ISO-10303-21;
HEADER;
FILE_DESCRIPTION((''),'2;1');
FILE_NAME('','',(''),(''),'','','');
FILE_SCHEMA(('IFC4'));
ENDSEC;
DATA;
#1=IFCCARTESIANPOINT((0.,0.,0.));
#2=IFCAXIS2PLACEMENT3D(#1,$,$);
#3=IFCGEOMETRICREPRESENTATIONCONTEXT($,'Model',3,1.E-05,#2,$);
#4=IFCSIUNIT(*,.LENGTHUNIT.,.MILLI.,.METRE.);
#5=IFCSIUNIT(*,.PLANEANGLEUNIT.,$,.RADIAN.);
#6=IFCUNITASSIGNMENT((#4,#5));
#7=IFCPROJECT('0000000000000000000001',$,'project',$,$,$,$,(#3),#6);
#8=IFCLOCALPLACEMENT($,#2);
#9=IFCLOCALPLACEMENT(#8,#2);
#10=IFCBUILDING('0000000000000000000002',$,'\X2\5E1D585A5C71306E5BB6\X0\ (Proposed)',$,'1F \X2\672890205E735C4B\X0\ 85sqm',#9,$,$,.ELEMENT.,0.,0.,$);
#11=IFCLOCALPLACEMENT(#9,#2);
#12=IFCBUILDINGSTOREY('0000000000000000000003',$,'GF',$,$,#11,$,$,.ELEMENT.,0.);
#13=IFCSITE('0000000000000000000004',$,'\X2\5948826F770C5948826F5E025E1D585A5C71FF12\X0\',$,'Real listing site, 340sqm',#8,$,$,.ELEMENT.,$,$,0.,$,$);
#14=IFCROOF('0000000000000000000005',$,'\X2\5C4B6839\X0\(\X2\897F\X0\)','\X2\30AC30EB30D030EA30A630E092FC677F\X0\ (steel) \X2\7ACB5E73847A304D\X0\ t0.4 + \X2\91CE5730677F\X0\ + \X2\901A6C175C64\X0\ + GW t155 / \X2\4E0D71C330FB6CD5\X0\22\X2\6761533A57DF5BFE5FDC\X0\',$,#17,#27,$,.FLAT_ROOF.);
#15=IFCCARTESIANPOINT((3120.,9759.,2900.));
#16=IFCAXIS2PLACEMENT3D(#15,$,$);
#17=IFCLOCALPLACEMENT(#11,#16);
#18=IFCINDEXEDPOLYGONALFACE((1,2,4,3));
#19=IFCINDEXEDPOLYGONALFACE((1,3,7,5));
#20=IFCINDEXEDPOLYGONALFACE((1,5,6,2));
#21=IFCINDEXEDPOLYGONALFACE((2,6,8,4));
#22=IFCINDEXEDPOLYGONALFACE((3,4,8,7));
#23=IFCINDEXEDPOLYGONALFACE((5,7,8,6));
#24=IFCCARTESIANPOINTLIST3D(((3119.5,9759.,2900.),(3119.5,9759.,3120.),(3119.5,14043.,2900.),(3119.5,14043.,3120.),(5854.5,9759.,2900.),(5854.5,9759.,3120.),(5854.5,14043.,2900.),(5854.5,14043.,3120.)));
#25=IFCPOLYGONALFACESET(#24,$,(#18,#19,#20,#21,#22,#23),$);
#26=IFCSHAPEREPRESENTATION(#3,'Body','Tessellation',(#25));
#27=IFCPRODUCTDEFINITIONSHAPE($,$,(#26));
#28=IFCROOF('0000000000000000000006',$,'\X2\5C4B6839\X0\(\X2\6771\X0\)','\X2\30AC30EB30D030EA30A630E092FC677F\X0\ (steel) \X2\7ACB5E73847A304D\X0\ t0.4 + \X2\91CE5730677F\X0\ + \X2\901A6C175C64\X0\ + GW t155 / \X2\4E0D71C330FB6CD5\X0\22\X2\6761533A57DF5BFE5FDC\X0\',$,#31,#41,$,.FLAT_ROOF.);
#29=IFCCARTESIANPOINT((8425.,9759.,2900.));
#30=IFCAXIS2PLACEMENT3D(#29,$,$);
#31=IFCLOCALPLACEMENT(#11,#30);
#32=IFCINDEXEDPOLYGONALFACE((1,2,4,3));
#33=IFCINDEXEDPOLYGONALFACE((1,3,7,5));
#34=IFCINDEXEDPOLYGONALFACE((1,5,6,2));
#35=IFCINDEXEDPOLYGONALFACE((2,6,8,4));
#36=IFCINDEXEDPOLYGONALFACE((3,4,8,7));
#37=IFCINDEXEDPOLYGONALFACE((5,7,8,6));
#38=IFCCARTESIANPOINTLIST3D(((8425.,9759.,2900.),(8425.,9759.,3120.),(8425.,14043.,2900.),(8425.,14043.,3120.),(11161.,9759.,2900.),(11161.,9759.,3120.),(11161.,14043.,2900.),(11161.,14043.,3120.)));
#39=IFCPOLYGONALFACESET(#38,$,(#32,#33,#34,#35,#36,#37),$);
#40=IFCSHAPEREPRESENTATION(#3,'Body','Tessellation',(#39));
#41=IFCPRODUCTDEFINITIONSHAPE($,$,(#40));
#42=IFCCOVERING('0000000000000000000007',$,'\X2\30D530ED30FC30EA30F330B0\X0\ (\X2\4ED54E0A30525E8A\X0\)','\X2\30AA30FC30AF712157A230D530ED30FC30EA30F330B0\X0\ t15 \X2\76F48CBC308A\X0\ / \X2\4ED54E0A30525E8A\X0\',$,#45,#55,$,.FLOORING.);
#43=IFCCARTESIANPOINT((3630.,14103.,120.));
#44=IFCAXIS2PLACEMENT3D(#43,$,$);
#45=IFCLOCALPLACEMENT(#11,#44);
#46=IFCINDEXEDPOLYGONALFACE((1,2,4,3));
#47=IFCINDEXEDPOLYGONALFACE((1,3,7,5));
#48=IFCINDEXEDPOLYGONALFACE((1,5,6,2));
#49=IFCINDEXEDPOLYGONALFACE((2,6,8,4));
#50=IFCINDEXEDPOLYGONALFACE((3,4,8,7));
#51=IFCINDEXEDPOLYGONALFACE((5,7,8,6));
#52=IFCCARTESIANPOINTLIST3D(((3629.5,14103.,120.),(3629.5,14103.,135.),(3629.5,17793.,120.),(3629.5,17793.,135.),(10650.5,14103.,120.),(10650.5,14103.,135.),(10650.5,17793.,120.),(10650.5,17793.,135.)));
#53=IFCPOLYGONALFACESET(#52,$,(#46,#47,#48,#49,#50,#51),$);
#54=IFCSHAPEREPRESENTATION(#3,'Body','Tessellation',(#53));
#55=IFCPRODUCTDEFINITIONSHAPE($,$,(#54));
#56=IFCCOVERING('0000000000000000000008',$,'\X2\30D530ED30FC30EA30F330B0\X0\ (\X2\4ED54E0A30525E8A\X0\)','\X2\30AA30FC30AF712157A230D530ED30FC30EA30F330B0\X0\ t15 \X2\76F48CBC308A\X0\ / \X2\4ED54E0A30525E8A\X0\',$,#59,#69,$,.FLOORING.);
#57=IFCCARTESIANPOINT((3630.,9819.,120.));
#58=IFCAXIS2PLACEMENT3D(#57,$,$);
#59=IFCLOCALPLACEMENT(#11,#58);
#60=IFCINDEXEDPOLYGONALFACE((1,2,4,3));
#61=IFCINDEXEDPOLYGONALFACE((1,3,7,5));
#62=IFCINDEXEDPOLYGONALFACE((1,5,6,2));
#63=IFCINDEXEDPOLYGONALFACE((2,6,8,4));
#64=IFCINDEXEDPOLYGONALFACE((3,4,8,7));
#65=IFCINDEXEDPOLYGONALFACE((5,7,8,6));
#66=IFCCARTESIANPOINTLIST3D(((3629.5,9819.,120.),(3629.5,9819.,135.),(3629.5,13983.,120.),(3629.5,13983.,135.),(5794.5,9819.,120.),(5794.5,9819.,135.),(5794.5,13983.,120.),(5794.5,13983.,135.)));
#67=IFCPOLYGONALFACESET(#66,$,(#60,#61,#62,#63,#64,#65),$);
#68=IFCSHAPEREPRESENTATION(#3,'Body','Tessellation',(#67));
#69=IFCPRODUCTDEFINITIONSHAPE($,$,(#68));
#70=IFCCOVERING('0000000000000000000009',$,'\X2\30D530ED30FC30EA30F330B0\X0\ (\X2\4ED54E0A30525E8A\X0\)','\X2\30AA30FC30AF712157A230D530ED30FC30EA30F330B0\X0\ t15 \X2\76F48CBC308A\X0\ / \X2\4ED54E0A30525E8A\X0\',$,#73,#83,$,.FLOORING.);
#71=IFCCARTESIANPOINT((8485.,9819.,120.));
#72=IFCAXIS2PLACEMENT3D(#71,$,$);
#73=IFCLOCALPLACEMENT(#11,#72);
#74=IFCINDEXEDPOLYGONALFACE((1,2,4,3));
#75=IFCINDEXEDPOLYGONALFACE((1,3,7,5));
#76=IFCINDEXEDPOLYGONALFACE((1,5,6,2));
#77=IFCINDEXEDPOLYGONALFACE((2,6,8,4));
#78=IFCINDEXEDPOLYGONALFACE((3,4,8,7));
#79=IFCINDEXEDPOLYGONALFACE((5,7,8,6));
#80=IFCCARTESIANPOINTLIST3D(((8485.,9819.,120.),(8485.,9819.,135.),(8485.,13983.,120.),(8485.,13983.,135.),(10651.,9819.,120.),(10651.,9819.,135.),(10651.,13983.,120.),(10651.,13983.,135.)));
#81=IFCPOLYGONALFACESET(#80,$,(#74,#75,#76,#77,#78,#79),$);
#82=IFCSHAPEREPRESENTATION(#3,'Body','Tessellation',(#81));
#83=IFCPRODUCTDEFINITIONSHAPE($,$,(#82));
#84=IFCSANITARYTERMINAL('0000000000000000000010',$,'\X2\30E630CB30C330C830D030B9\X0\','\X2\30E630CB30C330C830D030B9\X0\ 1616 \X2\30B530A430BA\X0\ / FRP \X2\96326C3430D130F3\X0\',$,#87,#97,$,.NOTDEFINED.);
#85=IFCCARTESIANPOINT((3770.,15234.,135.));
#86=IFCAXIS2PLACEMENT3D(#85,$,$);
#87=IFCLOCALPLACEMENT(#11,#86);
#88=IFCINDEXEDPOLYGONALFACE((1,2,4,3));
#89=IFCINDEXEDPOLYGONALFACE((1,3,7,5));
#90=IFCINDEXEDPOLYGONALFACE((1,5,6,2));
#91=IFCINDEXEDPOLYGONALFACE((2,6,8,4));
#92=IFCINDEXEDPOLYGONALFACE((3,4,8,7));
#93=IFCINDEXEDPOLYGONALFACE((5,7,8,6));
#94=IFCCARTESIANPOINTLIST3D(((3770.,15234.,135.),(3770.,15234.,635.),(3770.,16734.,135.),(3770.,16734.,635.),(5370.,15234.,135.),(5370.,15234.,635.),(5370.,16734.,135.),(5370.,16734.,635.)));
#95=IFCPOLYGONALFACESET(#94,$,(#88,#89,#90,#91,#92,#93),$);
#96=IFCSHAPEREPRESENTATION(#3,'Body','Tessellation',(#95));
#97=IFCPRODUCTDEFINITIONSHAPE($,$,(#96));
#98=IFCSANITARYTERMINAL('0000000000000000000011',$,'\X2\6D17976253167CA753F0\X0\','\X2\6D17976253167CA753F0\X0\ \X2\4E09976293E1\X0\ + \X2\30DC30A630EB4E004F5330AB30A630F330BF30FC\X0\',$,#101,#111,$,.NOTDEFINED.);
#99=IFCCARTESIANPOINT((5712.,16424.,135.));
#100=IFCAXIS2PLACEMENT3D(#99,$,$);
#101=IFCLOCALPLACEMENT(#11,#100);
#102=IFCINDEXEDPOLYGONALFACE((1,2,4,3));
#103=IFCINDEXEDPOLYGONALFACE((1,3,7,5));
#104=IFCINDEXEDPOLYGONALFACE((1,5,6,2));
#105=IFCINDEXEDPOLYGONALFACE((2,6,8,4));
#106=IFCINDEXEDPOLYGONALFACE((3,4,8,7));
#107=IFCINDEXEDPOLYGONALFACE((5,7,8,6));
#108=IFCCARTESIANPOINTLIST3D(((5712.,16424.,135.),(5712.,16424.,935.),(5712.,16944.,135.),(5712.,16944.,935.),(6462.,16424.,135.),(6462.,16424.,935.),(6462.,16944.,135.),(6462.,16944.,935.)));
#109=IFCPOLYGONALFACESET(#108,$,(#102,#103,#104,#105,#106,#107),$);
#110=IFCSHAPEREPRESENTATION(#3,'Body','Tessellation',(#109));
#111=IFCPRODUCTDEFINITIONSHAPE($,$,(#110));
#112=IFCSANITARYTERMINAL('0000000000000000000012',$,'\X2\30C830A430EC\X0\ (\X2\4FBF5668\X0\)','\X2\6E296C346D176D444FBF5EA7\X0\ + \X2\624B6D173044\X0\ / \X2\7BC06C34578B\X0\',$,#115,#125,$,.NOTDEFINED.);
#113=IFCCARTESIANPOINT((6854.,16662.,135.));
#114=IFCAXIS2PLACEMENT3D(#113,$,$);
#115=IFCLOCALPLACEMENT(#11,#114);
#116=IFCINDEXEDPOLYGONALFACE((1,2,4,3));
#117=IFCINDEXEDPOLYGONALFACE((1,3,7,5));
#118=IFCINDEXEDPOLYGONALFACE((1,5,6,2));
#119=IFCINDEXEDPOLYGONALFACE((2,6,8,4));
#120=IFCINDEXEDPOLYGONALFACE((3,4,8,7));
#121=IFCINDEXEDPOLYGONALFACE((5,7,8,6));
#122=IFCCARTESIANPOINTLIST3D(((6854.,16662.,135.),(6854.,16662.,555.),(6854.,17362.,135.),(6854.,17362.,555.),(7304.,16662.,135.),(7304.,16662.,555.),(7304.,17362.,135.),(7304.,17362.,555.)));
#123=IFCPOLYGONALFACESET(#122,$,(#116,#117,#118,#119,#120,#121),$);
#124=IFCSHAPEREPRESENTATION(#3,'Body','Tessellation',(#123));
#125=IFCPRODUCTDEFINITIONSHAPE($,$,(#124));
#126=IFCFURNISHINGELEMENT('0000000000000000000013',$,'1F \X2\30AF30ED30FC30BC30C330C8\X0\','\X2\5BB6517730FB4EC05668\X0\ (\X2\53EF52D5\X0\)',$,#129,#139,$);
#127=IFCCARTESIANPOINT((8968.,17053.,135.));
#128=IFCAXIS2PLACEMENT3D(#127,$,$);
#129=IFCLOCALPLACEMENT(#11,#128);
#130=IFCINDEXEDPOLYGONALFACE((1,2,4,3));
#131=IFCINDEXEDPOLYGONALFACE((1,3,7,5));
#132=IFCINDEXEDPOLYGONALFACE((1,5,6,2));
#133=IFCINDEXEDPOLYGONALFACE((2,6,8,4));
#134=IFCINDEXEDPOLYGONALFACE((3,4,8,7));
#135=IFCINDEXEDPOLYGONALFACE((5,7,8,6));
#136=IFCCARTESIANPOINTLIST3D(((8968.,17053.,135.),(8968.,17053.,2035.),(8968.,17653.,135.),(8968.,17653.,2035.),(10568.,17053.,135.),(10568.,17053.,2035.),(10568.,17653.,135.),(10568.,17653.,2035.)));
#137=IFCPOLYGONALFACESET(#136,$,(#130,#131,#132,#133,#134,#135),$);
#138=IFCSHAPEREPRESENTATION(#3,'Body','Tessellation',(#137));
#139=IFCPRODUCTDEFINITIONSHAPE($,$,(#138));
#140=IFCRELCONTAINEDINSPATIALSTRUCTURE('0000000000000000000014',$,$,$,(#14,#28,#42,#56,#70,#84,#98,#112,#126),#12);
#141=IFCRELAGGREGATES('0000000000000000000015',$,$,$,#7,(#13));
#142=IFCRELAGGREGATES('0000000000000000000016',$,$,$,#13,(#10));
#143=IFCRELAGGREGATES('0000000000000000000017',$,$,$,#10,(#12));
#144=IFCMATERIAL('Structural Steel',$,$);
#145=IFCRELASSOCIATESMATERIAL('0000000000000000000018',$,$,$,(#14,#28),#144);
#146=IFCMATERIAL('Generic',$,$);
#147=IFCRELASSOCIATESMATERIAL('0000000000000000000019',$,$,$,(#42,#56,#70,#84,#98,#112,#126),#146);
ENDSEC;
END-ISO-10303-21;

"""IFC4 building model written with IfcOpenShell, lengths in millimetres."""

from ifc_helpers import new_model, si_unit, frame, frame_2d, origin, place, context, project, spatial, rectangle, extrude, material, element, save


model = new_model("IFC4")

# Units and contexts
model_context = context("Model", 3, precision=1e-05, world=origin())
ifc_project = project(units=[si_unit("LENGTHUNIT", "METRE", prefix="MILLI"), si_unit("PLANEANGLEUNIT", "RADIAN")], contexts=[model_context])

# Site, building, storey
site_placement = place(None, origin())
site = spatial("IfcSite", under=ifc_project, at=site_placement, Name="奈良県奈良市帝塚山２", ObjectType="Real listing site, 340sqm", CompositionType="ELEMENT", RefElevation=0.0)
building_placement = place(site_placement, origin())
building = spatial("IfcBuilding", under=site, at=building_placement, Name="帝塚山の家 (Proposed)", ObjectType="1F 木造平屋 85sqm", CompositionType="ELEMENT", ElevationOfRefHeight=0.0, ElevationOfTerrain=0.0)
storey_placement = place(building_placement, origin())
storey = spatial("IfcBuildingStorey", under=building, at=storey_placement, Name="GF", CompositionType="ELEMENT", Elevation=0.0)

# Roofs
ifc_material_1 = material(Name="Structural Steel")
roof_1_placement = place(storey_placement, frame((3120.0, 9759.0, 2900.0)))
element("IfcRoof", 1, at=roof_1_placement, inside=storey, material=ifc_material_1, Name="屋根(西)", Description="ガルバリウム鋼板 (steel) 立平葺き t0.4 + 野地板 + 通気層 + GW t155 / 不燃・法22条区域対応", PredefinedType="FLAT_ROOF", context=model_context, shape_type="SweptSolid", body=[
    extrude(rectangle(XDim=2735.0, YDim=4284.0, at=frame_2d((1367.0, 2142.0))), frame((3120.0, 9759.0, 2900.0)), (0.0, 0.0, 1.0), 220.0),
])
roof_2_placement = place(storey_placement, frame((8425.0, 9759.0, 2900.0)))
element("IfcRoof", 2, at=roof_2_placement, inside=storey, material=ifc_material_1, Name="屋根(東)", Description="ガルバリウム鋼板 (steel) 立平葺き t0.4 + 野地板 + 通気層 + GW t155 / 不燃・法22条区域対応", PredefinedType="FLAT_ROOF", context=model_context, shape_type="SweptSolid", body=[
    extrude(rectangle(XDim=2736.0, YDim=4284.0, at=frame_2d((1368.0, 2142.0))), frame((8425.0, 9759.0, 2900.0)), (0.0, 0.0, 1.0), 220.0),
])

# Coverings
ifc_material_2 = material(Name="Generic")
covering_1_placement = place(storey_placement, frame((3630.0, 14103.0, 120.0)))
element("IfcCovering", 3, at=covering_1_placement, inside=storey, material=ifc_material_2, Name="フローリング (仕上げ床)", Description="オーク無垢フローリング t15 直貼り / 仕上げ床", PredefinedType="FLOORING", context=model_context, shape_type="SweptSolid", body=[
    extrude(rectangle(XDim=7021.0, YDim=3690.0, at=frame_2d((3510.0, 1845.0))), frame((3630.0, 14103.0, 120.0)), (0.0, 0.0, 1.0), 15.0),
])
covering_2_placement = place(storey_placement, frame((3630.0, 9819.0, 120.0)))
element("IfcCovering", 4, at=covering_2_placement, inside=storey, material=ifc_material_2, Name="フローリング (仕上げ床)", Description="オーク無垢フローリング t15 直貼り / 仕上げ床", PredefinedType="FLOORING", context=model_context, shape_type="SweptSolid", body=[
    extrude(rectangle(XDim=2165.0, YDim=4164.0, at=frame_2d((1082.0, 2082.0))), frame((3630.0, 9819.0, 120.0)), (0.0, 0.0, 1.0), 15.0),
])
covering_3_placement = place(storey_placement, frame((8485.0, 9819.0, 120.0)))
element("IfcCovering", 5, at=covering_3_placement, inside=storey, material=ifc_material_2, Name="フローリング (仕上げ床)", Description="オーク無垢フローリング t15 直貼り / 仕上げ床", PredefinedType="FLOORING", context=model_context, shape_type="SweptSolid", body=[
    extrude(rectangle(XDim=2166.0, YDim=4164.0, at=frame_2d((1083.0, 2082.0))), frame((8485.0, 9819.0, 120.0)), (0.0, 0.0, 1.0), 15.0),
])

# Sanitary terminals
sanitary_terminal_1_placement = place(storey_placement, frame((3770.0, 15234.0, 135.0)))
element("IfcSanitaryTerminal", 6, at=sanitary_terminal_1_placement, inside=storey, material=ifc_material_2, Name="ユニットバス", Description="ユニットバス 1616 サイズ / FRP 防水パン", PredefinedType="NOTDEFINED", context=model_context, shape_type="SweptSolid", body=[
    extrude(rectangle(XDim=1600.0, YDim=1500.0, at=frame_2d((800.0, 750.0))), frame((3770.0, 15234.0, 135.0)), (0.0, 0.0, 1.0), 500.0),
])
sanitary_terminal_2_placement = place(storey_placement, frame((5712.0, 16424.0, 135.0)))
element("IfcSanitaryTerminal", 7, at=sanitary_terminal_2_placement, inside=storey, material=ifc_material_2, Name="洗面化粧台", Description="洗面化粧台 三面鏡 + ボウル一体カウンター", PredefinedType="NOTDEFINED", context=model_context, shape_type="SweptSolid", body=[
    extrude(rectangle(XDim=750.0, YDim=520.0, at=frame_2d((375.0, 260.0))), frame((5712.0, 16424.0, 135.0)), (0.0, 0.0, 1.0), 800.0),
])
sanitary_terminal_3_placement = place(storey_placement, frame((6854.0, 16662.0, 135.0)))
element("IfcSanitaryTerminal", 8, at=sanitary_terminal_3_placement, inside=storey, material=ifc_material_2, Name="トイレ (便器)", Description="温水洗浄便座 + 手洗い / 節水型", PredefinedType="NOTDEFINED", context=model_context, shape_type="SweptSolid", body=[
    extrude(rectangle(XDim=450.0, YDim=700.0, at=frame_2d((225.0, 350.0))), frame((6854.0, 16662.0, 135.0)), (0.0, 0.0, 1.0), 420.0),
])

# Furnishing element
furnishing_placement = place(storey_placement, frame((8968.0, 17053.0, 135.0)))
element("IfcFurnishingElement", 9, at=furnishing_placement, inside=storey, material=ifc_material_2, Name="1F クローゼット", Description="家具・什器 (可動)", context=model_context, shape_type="SweptSolid", body=[
    extrude(rectangle(XDim=1600.0, YDim=600.0, at=frame_2d((800.0, 300.0))), frame((8968.0, 17053.0, 135.0)), (0.0, 0.0, 1.0), 1900.0),
])

save(model, "model.ifc")
